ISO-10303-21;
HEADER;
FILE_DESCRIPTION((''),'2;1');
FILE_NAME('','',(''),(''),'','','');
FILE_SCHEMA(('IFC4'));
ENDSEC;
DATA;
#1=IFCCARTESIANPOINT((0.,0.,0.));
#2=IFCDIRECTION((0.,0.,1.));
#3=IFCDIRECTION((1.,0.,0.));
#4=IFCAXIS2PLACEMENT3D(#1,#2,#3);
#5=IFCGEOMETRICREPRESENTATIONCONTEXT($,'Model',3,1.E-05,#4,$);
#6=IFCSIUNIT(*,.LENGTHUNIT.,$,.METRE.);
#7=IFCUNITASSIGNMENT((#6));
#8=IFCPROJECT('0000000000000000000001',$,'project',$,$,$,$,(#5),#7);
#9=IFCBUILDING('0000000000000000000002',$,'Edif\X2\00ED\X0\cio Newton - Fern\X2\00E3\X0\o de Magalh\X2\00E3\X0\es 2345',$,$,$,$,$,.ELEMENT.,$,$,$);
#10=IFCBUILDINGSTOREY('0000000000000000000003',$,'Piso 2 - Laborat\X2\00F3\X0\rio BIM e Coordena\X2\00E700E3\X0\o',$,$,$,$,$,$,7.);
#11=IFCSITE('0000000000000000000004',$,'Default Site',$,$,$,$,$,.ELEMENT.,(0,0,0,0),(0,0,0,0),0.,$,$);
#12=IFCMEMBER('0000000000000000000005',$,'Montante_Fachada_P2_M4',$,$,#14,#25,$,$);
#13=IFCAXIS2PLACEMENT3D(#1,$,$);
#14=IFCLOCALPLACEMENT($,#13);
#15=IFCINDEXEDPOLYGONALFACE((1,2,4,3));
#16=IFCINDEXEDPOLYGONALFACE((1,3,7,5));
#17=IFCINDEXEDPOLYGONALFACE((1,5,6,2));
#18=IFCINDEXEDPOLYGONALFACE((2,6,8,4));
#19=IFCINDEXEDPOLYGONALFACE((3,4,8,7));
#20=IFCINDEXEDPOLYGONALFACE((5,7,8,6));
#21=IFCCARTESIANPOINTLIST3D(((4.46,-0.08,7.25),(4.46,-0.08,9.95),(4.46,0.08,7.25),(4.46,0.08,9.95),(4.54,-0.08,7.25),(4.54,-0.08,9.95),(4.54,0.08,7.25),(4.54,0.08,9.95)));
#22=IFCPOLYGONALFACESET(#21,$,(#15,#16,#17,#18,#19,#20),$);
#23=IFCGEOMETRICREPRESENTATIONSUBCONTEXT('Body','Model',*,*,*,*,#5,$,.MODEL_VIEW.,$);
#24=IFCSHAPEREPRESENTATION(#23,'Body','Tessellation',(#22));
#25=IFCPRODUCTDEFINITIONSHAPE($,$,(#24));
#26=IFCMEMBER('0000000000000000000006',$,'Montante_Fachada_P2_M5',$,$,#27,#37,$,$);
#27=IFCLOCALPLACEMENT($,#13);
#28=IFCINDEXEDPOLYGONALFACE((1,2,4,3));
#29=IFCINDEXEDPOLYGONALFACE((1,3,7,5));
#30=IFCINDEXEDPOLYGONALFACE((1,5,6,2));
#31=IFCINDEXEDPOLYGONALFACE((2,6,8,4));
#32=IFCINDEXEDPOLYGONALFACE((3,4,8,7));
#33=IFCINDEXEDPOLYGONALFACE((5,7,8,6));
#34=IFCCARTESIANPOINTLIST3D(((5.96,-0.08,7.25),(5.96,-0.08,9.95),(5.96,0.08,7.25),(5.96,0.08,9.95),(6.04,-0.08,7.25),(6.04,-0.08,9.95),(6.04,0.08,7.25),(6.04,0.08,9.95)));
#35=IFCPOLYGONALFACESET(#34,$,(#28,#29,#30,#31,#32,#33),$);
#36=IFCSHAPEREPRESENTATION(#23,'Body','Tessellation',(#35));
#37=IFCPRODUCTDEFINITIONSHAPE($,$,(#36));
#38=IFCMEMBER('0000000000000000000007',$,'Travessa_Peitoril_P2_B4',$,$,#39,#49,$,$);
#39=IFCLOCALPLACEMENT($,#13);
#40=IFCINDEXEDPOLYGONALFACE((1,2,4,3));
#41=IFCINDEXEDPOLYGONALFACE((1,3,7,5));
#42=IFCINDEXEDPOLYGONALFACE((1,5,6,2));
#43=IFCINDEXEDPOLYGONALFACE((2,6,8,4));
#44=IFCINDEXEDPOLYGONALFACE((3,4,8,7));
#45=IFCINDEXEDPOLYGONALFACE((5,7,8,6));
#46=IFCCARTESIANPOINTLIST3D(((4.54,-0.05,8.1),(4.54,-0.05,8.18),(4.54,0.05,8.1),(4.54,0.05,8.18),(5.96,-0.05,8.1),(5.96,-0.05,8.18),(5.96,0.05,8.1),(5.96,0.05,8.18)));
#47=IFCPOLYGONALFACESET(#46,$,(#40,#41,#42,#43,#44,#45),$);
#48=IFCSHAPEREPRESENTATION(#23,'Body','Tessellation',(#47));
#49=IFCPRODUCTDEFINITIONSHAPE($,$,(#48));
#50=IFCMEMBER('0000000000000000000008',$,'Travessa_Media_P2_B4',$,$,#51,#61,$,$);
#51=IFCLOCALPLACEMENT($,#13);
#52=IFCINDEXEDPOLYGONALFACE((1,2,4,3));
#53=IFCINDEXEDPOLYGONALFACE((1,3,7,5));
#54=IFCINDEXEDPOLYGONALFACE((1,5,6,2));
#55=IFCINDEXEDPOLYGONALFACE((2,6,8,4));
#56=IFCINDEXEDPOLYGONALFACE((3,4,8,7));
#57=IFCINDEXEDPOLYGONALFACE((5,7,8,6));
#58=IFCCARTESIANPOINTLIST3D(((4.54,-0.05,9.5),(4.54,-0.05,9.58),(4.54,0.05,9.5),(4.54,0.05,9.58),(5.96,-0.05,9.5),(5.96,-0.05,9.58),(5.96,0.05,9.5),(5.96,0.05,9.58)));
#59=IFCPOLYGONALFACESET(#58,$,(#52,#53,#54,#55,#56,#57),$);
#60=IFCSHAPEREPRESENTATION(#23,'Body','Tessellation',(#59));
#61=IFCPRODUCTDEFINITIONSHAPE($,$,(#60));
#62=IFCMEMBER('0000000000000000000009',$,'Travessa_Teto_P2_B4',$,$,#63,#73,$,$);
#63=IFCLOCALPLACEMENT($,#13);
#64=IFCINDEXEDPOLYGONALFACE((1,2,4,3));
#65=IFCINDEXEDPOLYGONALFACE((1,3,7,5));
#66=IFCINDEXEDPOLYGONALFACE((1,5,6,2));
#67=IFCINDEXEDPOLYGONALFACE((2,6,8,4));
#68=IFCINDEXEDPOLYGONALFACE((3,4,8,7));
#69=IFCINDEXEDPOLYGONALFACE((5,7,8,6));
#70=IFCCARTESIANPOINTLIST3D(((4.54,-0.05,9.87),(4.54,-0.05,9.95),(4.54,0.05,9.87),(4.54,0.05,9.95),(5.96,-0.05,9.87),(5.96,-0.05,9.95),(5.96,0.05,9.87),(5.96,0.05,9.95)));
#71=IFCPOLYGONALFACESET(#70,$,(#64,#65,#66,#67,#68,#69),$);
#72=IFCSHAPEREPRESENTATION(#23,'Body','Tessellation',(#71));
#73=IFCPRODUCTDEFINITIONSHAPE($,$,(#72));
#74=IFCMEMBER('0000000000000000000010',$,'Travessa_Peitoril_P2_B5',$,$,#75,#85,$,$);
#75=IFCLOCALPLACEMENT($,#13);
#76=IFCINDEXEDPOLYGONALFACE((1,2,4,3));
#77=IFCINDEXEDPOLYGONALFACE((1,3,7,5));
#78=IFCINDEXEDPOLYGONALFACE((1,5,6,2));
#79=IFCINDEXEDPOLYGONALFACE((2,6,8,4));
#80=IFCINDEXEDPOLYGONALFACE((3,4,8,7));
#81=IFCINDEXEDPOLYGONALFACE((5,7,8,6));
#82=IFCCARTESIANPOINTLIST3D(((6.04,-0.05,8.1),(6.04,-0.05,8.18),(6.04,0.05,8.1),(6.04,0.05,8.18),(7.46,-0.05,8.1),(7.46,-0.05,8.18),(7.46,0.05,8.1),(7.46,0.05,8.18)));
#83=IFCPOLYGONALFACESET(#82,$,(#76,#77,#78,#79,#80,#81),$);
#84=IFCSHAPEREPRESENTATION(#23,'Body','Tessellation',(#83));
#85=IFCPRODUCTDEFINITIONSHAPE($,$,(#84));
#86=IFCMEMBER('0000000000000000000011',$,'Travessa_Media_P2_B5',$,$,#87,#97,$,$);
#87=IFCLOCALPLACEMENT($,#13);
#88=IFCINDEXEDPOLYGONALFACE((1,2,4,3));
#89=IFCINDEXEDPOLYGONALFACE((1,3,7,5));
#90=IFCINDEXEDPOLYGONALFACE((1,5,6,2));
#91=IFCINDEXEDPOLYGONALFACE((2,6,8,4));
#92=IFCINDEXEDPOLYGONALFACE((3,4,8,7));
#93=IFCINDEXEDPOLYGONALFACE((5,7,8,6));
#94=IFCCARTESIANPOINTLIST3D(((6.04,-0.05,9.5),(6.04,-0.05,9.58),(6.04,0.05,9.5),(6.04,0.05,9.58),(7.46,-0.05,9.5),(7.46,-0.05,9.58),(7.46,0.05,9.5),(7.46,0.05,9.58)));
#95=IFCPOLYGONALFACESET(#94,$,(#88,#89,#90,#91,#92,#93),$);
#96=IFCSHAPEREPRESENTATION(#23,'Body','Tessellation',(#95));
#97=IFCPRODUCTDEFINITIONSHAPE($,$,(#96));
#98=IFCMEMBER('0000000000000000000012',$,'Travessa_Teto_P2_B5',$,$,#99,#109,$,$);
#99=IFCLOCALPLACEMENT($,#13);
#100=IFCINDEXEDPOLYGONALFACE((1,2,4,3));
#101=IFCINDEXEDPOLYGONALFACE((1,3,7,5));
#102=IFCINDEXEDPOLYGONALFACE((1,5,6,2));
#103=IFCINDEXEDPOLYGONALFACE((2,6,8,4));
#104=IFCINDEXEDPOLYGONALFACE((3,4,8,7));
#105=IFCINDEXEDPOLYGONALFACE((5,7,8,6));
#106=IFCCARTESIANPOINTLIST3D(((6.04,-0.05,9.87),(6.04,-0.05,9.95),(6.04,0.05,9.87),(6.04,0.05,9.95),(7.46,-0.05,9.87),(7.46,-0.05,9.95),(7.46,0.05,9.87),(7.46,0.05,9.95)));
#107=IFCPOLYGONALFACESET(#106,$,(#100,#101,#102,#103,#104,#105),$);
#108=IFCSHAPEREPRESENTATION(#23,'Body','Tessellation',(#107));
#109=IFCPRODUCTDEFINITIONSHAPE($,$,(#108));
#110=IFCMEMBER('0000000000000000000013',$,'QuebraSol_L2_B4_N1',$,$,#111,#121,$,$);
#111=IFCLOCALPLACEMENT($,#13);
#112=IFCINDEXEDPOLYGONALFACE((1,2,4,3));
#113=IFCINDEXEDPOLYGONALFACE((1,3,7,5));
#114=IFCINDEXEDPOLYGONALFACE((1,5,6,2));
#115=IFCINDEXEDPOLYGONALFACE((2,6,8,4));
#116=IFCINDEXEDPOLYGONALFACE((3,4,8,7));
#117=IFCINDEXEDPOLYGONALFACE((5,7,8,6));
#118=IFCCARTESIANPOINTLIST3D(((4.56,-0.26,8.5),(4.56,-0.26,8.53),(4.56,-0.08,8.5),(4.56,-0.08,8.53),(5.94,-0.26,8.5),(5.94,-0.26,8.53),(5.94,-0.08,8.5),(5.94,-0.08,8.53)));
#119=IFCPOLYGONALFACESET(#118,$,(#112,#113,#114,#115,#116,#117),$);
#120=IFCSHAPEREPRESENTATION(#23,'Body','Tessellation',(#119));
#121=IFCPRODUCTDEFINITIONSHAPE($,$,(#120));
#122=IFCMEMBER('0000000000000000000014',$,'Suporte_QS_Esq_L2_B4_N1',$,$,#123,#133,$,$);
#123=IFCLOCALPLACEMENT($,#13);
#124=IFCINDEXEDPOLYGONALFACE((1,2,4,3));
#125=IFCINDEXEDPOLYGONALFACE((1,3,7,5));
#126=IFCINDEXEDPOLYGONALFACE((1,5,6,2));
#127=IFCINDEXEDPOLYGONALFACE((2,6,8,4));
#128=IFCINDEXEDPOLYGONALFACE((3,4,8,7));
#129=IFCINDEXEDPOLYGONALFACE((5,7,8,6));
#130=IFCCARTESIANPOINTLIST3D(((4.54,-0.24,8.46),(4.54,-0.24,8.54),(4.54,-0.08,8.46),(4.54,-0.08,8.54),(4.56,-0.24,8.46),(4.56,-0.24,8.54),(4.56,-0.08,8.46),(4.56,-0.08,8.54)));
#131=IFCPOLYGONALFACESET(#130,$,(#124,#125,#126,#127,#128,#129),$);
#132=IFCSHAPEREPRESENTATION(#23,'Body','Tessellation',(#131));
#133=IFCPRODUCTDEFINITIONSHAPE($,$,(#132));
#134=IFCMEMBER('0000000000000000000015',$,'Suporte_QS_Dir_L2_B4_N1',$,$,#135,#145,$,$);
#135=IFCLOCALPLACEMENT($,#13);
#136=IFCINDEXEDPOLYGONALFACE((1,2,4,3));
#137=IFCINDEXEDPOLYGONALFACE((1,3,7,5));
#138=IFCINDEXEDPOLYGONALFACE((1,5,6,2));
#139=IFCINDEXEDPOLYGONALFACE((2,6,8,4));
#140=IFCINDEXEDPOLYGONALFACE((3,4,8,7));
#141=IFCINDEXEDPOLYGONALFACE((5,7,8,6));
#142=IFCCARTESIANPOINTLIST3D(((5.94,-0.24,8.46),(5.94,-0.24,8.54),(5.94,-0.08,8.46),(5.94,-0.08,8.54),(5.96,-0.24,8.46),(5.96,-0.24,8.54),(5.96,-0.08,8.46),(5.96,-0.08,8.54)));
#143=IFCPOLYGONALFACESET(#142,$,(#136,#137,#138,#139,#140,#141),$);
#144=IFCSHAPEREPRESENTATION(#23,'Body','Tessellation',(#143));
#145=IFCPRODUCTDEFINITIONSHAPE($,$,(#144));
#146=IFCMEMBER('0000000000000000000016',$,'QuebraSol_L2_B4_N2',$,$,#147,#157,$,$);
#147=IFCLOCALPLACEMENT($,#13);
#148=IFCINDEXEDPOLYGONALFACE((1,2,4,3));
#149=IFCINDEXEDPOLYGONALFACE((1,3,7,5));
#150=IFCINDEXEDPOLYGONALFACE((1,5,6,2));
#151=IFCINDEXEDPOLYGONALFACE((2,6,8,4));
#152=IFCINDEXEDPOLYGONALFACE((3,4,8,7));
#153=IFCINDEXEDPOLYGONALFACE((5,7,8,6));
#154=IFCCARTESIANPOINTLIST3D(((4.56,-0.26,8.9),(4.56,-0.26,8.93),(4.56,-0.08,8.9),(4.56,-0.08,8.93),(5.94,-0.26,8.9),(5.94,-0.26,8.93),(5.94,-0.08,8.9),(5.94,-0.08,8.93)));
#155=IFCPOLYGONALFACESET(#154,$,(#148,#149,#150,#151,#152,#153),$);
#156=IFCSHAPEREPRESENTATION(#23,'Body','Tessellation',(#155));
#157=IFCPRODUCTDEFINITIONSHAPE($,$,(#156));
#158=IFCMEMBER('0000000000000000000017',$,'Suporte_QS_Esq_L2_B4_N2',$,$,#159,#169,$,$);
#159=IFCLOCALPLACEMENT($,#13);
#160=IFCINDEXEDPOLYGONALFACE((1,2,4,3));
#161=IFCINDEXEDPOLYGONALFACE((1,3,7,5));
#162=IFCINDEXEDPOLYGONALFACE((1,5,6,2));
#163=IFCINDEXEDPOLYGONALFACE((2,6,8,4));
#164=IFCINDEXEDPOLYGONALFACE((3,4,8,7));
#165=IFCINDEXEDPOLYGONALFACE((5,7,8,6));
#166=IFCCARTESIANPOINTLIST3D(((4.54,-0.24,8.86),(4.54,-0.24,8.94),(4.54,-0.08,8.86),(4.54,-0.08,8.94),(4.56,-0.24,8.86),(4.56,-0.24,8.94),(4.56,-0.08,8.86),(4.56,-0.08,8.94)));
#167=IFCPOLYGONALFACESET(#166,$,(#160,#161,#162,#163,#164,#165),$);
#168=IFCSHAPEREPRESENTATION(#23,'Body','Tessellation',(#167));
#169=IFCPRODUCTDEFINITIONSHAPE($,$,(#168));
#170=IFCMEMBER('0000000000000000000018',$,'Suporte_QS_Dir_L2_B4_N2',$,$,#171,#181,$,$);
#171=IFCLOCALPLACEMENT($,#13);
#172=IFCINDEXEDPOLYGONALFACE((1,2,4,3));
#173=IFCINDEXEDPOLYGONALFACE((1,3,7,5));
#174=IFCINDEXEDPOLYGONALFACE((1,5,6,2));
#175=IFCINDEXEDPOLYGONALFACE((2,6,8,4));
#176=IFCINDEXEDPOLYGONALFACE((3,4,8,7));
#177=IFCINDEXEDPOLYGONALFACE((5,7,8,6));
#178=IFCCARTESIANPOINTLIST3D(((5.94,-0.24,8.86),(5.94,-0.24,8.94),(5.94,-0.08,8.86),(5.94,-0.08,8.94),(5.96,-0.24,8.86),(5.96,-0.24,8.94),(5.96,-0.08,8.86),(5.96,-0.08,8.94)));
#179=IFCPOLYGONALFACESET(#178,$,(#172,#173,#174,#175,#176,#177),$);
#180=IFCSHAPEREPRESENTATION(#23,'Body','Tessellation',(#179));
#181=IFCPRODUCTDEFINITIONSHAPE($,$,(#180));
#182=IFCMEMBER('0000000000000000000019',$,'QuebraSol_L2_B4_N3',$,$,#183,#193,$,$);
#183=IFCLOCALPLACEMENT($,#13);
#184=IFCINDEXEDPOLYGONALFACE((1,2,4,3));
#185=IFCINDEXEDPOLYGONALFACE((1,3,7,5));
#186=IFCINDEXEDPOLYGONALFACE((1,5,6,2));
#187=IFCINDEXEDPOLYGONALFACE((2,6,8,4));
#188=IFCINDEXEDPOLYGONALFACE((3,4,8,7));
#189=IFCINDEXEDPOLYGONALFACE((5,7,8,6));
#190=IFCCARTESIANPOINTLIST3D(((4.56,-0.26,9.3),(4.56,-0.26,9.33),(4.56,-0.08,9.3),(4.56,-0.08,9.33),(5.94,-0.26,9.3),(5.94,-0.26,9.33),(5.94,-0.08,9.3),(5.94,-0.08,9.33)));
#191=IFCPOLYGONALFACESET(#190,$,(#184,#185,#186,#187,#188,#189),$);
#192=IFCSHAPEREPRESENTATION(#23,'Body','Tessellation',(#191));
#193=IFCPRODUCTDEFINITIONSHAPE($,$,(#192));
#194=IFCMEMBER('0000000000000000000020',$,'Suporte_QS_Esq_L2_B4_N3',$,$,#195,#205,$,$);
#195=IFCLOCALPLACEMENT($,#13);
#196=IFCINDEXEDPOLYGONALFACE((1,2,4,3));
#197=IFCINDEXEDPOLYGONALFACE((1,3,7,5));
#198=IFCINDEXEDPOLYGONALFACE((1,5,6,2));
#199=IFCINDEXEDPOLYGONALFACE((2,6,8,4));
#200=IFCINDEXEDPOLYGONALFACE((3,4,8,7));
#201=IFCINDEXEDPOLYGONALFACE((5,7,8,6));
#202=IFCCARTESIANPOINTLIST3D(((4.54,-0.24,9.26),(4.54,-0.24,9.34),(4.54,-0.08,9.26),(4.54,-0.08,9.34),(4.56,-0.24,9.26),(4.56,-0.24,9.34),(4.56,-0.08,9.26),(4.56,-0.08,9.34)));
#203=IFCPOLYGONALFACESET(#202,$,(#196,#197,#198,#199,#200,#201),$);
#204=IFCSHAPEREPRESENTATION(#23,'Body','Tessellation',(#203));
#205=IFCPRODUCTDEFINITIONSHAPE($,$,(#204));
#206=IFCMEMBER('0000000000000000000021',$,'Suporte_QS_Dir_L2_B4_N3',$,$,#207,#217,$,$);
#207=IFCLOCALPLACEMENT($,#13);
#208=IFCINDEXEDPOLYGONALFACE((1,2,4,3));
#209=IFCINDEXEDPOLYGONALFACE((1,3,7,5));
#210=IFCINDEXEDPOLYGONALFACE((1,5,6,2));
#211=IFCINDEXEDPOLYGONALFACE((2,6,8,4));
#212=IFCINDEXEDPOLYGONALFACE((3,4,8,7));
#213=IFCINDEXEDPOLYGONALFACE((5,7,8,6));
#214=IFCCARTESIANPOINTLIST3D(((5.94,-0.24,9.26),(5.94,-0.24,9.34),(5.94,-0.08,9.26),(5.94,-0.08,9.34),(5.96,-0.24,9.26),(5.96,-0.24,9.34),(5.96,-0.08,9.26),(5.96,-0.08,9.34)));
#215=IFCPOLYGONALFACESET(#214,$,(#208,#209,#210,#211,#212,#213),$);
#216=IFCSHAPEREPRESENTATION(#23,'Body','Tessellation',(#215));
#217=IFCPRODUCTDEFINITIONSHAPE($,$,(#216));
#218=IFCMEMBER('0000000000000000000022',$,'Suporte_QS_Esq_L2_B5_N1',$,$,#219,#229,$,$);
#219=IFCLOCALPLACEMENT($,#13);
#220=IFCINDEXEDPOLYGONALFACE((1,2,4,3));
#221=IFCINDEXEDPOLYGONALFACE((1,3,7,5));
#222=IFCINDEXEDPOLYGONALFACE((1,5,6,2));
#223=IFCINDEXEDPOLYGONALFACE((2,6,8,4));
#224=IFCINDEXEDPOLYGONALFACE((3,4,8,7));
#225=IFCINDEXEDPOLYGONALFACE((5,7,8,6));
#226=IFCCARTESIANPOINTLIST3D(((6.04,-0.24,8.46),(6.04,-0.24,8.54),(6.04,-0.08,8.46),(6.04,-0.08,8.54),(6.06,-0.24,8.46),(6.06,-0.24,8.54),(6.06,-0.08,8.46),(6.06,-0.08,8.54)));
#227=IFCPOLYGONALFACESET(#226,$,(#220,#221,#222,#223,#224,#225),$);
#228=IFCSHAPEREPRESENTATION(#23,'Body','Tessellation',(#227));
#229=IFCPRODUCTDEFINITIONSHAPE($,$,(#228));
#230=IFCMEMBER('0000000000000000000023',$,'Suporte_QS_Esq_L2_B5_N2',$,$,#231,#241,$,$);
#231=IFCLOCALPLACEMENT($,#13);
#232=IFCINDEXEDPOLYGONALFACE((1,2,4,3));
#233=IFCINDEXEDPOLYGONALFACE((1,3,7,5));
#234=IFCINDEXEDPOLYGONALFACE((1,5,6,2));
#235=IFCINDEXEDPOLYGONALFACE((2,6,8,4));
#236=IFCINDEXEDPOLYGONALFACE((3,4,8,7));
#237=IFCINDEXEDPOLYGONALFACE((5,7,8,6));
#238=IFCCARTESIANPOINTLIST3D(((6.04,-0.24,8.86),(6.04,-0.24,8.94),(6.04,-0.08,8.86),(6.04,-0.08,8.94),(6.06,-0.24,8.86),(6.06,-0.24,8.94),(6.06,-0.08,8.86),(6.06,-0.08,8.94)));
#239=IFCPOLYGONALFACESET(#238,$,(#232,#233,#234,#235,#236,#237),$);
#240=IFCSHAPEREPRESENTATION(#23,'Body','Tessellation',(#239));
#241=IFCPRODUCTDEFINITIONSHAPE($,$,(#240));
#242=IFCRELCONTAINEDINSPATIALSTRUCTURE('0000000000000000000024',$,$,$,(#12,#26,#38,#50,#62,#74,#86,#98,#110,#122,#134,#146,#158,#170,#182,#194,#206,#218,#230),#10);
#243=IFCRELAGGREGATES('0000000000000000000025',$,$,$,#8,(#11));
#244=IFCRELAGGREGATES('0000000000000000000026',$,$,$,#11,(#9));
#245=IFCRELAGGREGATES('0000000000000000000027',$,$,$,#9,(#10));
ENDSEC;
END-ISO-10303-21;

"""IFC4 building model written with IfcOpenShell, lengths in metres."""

from ifc_helpers import new_model, si_unit, frame, frame_2d, origin_with_axes, place, context, subcontext, project, spatial, rectangle, extrude, element, save


model = new_model("IFC4")

# Units and contexts
model_context = context("Model", 3, precision=1e-05, world=origin_with_axes())
body_context = subcontext(model_context, "Body", "Model", "MODEL_VIEW")
ifc_project = project(units=[si_unit("LENGTHUNIT", "METRE")], contexts=[model_context])

# Site, building, storey
site = spatial("IfcSite", under=ifc_project, Name="Default Site", CompositionType="ELEMENT", RefLatitude=(0, 0, 0, 0), RefLongitude=(0, 0, 0, 0), RefElevation=0.0)
building = spatial("IfcBuilding", under=site, Name="Edifício Newton - Fernão de Magalhães 2345", CompositionType="ELEMENT")
storey = spatial("IfcBuildingStorey", under=building, Name="Piso 2 - Laboratório BIM e Coordenação", Elevation=7.0)

# Members
for number, where, z_axis, x_axis, name in (
    (1, (4.46, -0.08, 7.25), (0.0, 0.0, 1.0), (1.0, 0.0, 0.0), "Montante_Fachada_P2_M4"),
    (2, (5.96, -0.08, 7.25), (0.0, 0.0, 1.0), (1.0, 0.0, 0.0), "Montante_Fachada_P2_M5"),
):
    element("IfcMember", number, at=place(None, frame(where, z_axis=z_axis, x_axis=x_axis)), inside=storey, Name=name, context=body_context, shape_type="SweptSolid", body=[
        extrude(rectangle(XDim=0.08, YDim=0.16, at=frame_2d((0.04, 0.08))), origin_with_axes(), (0.0, 0.0, 1.0), 2.7),
    ])
for number, where, z_axis, x_axis, name in (
    (3, (4.54, -0.05, 8.1), (0.0, 0.0, 1.0), (1.0, 0.0, 0.0), "Travessa_Peitoril_P2_B4"),
    (4, (4.54, -0.05, 9.5), (0.0, 0.0, 1.0), (1.0, 0.0, 0.0), "Travessa_Media_P2_B4"),
    (5, (4.54, -0.05, 9.87), (0.0, 0.0, 1.0), (1.0, 0.0, 0.0), "Travessa_Teto_P2_B4"),
    (6, (6.04, -0.05, 8.1), (0.0, 0.0, 1.0), (1.0, 0.0, 0.0), "Travessa_Peitoril_P2_B5"),
    (7, (6.04, -0.05, 9.5), (0.0, 0.0, 1.0), (1.0, 0.0, 0.0), "Travessa_Media_P2_B5"),
    (8, (6.04, -0.05, 9.87), (0.0, 0.0, 1.0), (1.0, 0.0, 0.0), "Travessa_Teto_P2_B5"),
):
    element("IfcMember", number, at=place(None, frame(where, z_axis=z_axis, x_axis=x_axis)), inside=storey, Name=name, context=body_context, shape_type="SweptSolid", body=[
        extrude(rectangle(XDim=1.42, YDim=0.1, at=frame_2d((0.71, 0.05))), origin_with_axes(), (0.0, 0.0, 1.0), 0.08),
    ])
member_1_placement = place(None, frame((4.56, -0.26, 8.5), z_axis=(0.0, 0.0, 1.0), x_axis=(1.0, 0.0, 0.0)))
element("IfcMember", 9, at=member_1_placement, inside=storey, Name="QuebraSol_L2_B4_N1", context=body_context, shape_type="SweptSolid", body=[
    extrude(rectangle(XDim=1.38, YDim=0.18, at=frame_2d((0.69, 0.09))), origin_with_axes(), (0.0, 0.0, 1.0), 0.03),
])
for number, where, z_axis, x_axis, name in (
    (10, (4.54, -0.24, 8.46), (0.0, 0.0, 1.0), (1.0, 0.0, 0.0), "Suporte_QS_Esq_L2_B4_N1"),
    (11, (5.94, -0.24, 8.46), (0.0, 0.0, 1.0), (1.0, 0.0, 0.0), "Suporte_QS_Dir_L2_B4_N1"),
):
    element("IfcMember", number, at=place(None, frame(where, z_axis=z_axis, x_axis=x_axis)), inside=storey, Name=name, context=body_context, shape_type="SweptSolid", body=[
        extrude(rectangle(XDim=0.02, YDim=0.16, at=frame_2d((0.01, 0.08))), origin_with_axes(), (0.0, 0.0, 1.0), 0.08),
    ])
member_2_placement = place(None, frame((4.56, -0.26, 8.9), z_axis=(0.0, 0.0, 1.0), x_axis=(1.0, 0.0, 0.0)))
element("IfcMember", 12, at=member_2_placement, inside=storey, Name="QuebraSol_L2_B4_N2", context=body_context, shape_type="SweptSolid", body=[
    extrude(rectangle(XDim=1.38, YDim=0.18, at=frame_2d((0.69, 0.09))), origin_with_axes(), (0.0, 0.0, 1.0), 0.03),
])
for number, where, z_axis, x_axis, name in (
    (13, (4.54, -0.24, 8.86), (0.0, 0.0, 1.0), (1.0, 0.0, 0.0), "Suporte_QS_Esq_L2_B4_N2"),
    (14, (5.94, -0.24, 8.86), (0.0, 0.0, 1.0), (1.0, 0.0, 0.0), "Suporte_QS_Dir_L2_B4_N2"),
):
    element("IfcMember", number, at=place(None, frame(where, z_axis=z_axis, x_axis=x_axis)), inside=storey, Name=name, context=body_context, shape_type="SweptSolid", body=[
        extrude(rectangle(XDim=0.02, YDim=0.16, at=frame_2d((0.01, 0.08))), origin_with_axes(), (0.0, 0.0, 1.0), 0.08),
    ])
member_3_placement = place(None, frame((4.56, -0.26, 9.3), z_axis=(0.0, 0.0, 1.0), x_axis=(1.0, 0.0, 0.0)))
element("IfcMember", 15, at=member_3_placement, inside=storey, Name="QuebraSol_L2_B4_N3", context=body_context, shape_type="SweptSolid", body=[
    extrude(rectangle(XDim=1.38, YDim=0.18, at=frame_2d((0.69, 0.09))), origin_with_axes(), (0.0, 0.0, 1.0), 0.03),
])
for number, where, z_axis, x_axis, name in (
    (16, (4.54, -0.24, 9.26), (0.0, 0.0, 1.0), (1.0, 0.0, 0.0), "Suporte_QS_Esq_L2_B4_N3"),
    (17, (5.94, -0.24, 9.26), (0.0, 0.0, 1.0), (1.0, 0.0, 0.0), "Suporte_QS_Dir_L2_B4_N3"),
    (18, (6.04, -0.24, 8.46), (0.0, 0.0, 1.0), (1.0, 0.0, 0.0), "Suporte_QS_Esq_L2_B5_N1"),
    (19, (6.04, -0.24, 8.86), (0.0, 0.0, 1.0), (1.0, 0.0, 0.0), "Suporte_QS_Esq_L2_B5_N2"),
):
    element("IfcMember", number, at=place(None, frame(where, z_axis=z_axis, x_axis=x_axis)), inside=storey, Name=name, context=body_context, shape_type="SweptSolid", body=[
        extrude(rectangle(XDim=0.02, YDim=0.16, at=frame_2d((0.01, 0.08))), origin_with_axes(), (0.0, 0.0, 1.0), 0.08),
    ])

save(model, "model.ifc")
